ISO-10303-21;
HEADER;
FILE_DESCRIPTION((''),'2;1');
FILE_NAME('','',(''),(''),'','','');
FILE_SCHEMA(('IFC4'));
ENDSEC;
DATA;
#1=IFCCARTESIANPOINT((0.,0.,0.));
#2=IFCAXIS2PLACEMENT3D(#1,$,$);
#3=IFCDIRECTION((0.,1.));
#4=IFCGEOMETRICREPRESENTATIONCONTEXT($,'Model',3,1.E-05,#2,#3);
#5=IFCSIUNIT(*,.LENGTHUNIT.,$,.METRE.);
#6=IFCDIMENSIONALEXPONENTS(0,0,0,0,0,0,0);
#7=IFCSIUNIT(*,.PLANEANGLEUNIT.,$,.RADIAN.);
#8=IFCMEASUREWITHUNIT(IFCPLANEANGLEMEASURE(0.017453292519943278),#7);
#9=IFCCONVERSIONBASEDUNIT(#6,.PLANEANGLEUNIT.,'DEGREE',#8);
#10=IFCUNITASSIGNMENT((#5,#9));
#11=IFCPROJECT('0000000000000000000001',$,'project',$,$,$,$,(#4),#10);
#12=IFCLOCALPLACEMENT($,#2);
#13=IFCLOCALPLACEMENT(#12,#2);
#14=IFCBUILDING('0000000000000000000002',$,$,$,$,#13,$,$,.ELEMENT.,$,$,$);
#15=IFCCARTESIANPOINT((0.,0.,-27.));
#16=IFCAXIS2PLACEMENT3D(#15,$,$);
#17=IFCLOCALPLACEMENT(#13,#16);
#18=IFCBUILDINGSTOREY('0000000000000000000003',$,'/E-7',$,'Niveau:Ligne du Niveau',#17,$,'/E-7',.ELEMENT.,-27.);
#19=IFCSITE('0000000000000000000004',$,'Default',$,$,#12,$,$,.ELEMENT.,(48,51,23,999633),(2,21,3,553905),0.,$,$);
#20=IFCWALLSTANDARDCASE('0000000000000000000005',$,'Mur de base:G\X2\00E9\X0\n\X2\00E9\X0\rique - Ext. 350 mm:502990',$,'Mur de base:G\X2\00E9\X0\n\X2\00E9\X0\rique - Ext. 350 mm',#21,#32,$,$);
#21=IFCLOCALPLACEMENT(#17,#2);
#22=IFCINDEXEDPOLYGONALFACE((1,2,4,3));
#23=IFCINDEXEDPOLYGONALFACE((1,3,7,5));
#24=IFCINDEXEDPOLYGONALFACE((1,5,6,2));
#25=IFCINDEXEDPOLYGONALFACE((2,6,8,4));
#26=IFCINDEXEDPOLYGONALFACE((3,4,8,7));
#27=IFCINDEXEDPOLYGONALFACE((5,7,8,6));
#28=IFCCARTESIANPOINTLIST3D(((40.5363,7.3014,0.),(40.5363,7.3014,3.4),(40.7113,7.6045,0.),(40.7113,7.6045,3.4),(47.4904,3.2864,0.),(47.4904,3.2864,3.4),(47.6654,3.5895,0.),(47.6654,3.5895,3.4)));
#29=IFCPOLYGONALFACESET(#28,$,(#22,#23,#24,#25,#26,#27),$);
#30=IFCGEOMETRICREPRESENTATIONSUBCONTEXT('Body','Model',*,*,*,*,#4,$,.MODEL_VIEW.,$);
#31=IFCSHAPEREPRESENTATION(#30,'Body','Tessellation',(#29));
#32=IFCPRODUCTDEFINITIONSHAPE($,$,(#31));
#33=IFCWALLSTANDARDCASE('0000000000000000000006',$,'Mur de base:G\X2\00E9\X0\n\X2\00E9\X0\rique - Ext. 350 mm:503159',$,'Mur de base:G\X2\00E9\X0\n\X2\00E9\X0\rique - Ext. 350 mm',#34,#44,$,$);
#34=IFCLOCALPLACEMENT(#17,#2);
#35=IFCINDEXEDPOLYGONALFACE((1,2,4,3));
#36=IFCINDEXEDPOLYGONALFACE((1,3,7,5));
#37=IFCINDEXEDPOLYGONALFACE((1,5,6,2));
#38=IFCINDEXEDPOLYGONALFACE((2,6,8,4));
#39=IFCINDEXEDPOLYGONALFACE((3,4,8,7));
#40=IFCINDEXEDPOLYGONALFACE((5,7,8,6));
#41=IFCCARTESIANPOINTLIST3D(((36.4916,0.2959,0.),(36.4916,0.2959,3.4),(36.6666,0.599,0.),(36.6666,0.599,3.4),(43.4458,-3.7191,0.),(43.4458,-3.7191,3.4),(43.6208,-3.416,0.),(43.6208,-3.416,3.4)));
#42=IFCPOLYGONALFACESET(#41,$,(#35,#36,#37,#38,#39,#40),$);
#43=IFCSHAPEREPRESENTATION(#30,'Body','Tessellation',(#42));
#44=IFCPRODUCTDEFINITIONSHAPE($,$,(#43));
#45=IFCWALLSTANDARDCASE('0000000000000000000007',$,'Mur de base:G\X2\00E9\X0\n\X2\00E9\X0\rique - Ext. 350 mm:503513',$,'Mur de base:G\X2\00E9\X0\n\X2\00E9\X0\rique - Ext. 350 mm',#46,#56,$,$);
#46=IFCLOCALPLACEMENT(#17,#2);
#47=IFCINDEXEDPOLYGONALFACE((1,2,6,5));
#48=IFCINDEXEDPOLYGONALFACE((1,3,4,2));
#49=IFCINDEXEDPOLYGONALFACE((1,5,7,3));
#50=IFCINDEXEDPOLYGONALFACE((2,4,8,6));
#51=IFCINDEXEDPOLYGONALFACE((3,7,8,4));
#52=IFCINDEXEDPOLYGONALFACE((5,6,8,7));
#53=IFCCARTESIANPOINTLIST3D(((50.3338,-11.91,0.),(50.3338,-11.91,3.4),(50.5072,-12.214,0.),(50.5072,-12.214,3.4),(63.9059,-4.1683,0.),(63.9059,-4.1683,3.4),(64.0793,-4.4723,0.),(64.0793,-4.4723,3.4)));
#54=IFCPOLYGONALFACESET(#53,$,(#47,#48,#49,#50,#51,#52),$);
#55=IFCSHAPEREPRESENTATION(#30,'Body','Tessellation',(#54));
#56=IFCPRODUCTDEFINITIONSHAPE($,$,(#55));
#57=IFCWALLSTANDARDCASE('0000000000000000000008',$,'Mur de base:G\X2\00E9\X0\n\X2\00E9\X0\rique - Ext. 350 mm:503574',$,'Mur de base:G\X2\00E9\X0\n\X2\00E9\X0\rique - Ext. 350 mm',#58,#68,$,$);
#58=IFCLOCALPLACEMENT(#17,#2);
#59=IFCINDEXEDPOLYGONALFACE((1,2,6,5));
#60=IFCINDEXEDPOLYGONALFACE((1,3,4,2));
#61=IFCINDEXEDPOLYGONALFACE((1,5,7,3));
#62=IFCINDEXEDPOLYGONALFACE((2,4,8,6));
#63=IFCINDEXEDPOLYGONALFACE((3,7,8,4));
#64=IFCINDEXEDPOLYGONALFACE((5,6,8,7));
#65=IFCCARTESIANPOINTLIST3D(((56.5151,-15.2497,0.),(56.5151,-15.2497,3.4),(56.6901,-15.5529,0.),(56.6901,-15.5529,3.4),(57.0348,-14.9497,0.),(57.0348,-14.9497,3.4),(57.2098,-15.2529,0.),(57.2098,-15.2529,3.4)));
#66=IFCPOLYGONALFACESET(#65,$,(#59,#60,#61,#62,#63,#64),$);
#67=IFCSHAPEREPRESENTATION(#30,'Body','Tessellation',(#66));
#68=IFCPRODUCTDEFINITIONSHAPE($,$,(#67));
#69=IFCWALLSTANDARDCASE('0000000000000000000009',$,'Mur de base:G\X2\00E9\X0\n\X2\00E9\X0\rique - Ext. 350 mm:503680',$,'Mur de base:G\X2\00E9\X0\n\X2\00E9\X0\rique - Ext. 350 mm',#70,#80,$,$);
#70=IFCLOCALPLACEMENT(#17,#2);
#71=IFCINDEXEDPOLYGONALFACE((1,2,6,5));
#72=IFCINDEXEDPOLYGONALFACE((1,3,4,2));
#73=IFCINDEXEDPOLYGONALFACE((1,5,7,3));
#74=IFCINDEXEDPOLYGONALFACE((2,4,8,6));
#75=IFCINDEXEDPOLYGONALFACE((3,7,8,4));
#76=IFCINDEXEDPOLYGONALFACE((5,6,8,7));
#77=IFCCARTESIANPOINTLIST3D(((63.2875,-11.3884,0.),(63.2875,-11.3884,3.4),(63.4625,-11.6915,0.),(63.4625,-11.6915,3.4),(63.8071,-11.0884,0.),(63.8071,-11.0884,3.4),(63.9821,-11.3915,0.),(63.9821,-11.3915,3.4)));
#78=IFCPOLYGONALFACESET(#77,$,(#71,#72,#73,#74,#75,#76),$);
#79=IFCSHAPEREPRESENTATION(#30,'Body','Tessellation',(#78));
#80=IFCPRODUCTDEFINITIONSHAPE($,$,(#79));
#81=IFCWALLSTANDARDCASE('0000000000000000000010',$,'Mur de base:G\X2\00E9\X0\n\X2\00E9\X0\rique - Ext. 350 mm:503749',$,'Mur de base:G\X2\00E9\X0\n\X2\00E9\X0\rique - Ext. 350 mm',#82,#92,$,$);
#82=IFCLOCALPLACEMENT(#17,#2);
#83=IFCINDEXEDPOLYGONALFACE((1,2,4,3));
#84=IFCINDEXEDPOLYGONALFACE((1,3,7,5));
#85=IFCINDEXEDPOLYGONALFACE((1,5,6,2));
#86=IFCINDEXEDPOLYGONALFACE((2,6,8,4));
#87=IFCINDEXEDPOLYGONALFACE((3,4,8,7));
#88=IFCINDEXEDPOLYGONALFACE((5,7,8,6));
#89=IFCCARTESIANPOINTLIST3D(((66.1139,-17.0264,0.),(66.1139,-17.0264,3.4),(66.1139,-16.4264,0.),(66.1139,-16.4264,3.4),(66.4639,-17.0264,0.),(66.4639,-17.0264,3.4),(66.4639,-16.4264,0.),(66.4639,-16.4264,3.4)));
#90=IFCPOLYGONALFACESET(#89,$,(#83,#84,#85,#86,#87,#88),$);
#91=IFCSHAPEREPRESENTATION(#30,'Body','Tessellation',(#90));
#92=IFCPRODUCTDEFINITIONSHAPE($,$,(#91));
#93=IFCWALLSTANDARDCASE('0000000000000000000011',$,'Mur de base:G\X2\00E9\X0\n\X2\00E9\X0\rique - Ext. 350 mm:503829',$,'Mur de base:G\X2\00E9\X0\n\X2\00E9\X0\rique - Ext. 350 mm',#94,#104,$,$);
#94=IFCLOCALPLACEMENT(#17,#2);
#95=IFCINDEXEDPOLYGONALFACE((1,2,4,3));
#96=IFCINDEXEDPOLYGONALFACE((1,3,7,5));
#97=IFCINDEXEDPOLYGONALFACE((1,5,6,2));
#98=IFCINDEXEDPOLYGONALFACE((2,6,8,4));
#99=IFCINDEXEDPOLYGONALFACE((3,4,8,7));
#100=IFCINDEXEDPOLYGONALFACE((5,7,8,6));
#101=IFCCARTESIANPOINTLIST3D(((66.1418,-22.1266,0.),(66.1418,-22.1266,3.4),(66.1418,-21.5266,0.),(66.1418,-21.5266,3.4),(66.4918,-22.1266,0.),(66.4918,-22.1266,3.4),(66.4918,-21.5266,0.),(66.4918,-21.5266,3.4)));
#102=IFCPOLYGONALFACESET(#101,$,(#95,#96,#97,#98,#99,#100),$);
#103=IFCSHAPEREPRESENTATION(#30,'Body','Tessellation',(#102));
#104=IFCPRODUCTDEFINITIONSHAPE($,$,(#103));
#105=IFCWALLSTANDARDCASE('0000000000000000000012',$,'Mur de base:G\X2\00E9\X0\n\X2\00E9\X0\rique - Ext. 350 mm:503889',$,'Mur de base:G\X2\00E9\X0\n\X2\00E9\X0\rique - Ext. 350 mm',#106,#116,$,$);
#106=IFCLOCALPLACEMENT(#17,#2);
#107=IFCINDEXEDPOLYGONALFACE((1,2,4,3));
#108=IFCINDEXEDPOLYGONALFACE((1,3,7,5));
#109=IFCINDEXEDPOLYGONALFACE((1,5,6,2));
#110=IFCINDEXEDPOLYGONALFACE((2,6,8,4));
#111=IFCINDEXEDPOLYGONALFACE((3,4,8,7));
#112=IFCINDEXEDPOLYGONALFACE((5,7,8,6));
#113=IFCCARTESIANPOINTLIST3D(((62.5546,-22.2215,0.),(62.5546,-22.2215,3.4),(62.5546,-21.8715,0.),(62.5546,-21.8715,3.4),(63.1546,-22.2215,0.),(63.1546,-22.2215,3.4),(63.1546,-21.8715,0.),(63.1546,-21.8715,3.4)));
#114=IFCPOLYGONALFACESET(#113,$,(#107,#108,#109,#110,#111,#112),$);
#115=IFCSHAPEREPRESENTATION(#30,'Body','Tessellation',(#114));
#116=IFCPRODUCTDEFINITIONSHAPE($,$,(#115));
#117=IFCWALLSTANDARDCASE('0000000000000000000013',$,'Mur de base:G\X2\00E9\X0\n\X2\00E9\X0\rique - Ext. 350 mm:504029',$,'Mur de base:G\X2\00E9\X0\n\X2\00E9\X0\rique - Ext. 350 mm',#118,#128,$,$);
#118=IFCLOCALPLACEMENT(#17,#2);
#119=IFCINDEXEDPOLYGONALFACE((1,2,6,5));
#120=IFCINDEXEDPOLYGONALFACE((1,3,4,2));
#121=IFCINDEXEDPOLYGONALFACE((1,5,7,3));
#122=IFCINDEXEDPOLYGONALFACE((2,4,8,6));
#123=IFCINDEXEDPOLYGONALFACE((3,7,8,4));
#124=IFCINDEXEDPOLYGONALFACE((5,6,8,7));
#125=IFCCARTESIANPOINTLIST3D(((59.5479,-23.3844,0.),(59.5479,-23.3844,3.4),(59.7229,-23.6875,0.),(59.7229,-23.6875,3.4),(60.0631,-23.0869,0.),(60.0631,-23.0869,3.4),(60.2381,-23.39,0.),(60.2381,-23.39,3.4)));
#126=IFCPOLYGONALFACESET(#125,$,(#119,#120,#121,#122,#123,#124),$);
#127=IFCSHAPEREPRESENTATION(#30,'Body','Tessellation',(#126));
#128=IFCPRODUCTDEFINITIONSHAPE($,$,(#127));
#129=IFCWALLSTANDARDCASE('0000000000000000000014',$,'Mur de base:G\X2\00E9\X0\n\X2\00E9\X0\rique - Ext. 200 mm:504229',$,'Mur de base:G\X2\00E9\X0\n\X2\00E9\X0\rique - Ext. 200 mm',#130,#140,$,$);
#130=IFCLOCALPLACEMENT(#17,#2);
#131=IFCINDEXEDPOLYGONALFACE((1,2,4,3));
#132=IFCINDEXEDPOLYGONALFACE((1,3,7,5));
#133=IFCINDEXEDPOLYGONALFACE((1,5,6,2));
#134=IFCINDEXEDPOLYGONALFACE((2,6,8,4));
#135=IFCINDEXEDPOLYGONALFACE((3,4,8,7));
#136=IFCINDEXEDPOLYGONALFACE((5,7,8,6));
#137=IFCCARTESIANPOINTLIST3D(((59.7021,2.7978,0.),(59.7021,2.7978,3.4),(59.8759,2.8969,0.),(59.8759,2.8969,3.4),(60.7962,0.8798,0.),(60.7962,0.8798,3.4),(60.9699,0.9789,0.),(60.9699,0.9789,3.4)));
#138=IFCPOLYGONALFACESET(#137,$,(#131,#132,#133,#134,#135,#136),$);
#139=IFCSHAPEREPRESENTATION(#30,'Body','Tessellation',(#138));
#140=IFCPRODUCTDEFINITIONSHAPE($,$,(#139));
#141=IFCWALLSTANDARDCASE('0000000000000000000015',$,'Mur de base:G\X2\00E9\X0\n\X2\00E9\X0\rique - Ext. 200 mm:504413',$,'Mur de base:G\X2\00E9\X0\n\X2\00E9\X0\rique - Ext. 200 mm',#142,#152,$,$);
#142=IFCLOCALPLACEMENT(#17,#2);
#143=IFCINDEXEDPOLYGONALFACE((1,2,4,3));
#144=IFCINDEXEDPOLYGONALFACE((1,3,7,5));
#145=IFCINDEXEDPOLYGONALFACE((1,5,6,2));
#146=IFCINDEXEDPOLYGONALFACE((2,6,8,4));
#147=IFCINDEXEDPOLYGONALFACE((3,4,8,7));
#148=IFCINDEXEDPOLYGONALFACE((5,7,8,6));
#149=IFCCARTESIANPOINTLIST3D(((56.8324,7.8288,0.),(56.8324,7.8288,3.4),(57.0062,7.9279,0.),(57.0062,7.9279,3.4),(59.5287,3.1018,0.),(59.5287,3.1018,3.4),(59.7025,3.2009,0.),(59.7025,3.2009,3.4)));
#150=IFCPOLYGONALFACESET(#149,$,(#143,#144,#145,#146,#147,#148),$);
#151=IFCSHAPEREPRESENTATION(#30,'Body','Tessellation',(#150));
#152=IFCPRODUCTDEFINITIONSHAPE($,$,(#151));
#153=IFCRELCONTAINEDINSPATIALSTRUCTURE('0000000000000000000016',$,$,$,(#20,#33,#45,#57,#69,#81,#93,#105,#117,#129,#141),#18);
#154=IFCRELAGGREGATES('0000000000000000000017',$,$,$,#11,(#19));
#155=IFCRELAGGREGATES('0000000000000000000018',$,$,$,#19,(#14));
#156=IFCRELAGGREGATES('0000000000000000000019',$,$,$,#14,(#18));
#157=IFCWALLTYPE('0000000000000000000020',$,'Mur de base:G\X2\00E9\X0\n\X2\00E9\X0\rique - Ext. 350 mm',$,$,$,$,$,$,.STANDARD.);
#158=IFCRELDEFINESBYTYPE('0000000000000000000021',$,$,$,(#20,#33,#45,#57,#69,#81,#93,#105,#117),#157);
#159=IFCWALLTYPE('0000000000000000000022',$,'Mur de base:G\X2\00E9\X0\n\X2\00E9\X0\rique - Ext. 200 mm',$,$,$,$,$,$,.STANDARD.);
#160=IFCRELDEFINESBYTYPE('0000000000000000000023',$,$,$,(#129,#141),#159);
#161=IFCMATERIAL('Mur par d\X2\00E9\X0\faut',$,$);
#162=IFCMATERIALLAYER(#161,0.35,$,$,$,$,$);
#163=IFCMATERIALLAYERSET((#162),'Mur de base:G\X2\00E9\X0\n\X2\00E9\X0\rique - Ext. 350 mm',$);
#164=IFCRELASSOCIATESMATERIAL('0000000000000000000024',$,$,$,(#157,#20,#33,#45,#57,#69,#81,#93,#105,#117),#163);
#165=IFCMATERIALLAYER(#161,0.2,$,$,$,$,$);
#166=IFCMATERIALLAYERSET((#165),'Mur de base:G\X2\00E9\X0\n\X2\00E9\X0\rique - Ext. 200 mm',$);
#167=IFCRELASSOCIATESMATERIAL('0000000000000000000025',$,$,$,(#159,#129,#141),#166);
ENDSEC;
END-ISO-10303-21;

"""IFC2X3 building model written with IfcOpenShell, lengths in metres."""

from ifc_helpers import new_model, entity, si_unit, converted_unit, direction, frame, frame_2d, origin, place, context, subcontext, project, spatial, rectangle, extrude, material, layer, layer_set, layer_usage, type_object, element, save


model = new_model("IFC2X3")

# Units and contexts
model_context = context("Model", 3, precision=1e-05, world=origin(), true_north=direction((0.0, 1.0)))
body_context = subcontext(model_context, "Body", "Model", "MODEL_VIEW")
ifc_project = project(units=[si_unit("LENGTHUNIT", "METRE"), converted_unit("PLANEANGLEUNIT", "DEGREE", entity("IfcPlaneAngleMeasure", 0.017453292519943278), si_unit("PLANEANGLEUNIT", "RADIAN"), dimensions=[0, 0, 0, 0, 0, 0, 0])], contexts=[model_context])

# Site, building, storey
site_placement = place(None, origin())
site = spatial("IfcSite", under=ifc_project, at=site_placement, Name="Default", CompositionType="ELEMENT", RefLatitude=(48, 51, 23, 999633), RefLongitude=(2, 21, 3, 553905), RefElevation=0.0)
building_placement = place(site_placement, origin())
building = spatial("IfcBuilding", under=site, at=building_placement, CompositionType="ELEMENT")
storey_placement = place(building_placement, frame((0.0, 0.0, -27.0)))
storey = spatial("IfcBuildingStorey", under=building, at=storey_placement, Name="/E-7", ObjectType="Niveau:Ligne du Niveau", LongName="/E-7", CompositionType="ELEMENT", Elevation=-27.0)

# Shared definitions
ifc_material_1 = material(Name="Mur par défaut")
ifc_layer_1 = layer(ifc_material_1, 0.35)
ifc_layer_set_1 = layer_set([ifc_layer_1], Name="Mur de base:Générique - Ext. 350 mm")
wall_type_1 = type_object("IfcWallType", Name="Mur de base:Générique - Ext. 350 mm", PredefinedType="STANDARD", material=ifc_layer_set_1)

# Walls
ifc_layer_usage_1 = layer_usage(ifc_layer_set_1, "AXIS2", "NEGATIVE", 0.175)
wall_1_placement = place(storey_placement, frame((40.6238, 7.4529, 0.0), z_axis=(0.0, 0.0, 1.0), x_axis=(0.866025, -0.5, 0.0)))
element("IfcWallStandardCase", 1, at=wall_1_placement, inside=storey, type_object=wall_type_1, material=ifc_layer_usage_1, Name="Mur de base:Générique - Ext. 350 mm:502990", ObjectType="Mur de base:Générique - Ext. 350 mm", context=body_context, shape_type="SweptSolid", body=[
    extrude(rectangle(XDim=8.03, YDim=0.35, at=frame_2d((4.015, 0.0), x_axis=(-1.0, 0.0))), origin(), (0.0, 0.0, 1.0), 3.4),
])
ifc_layer_usage_2 = layer_usage(ifc_layer_set_1, "AXIS2", "NEGATIVE", 0.175)
wall_2_placement = place(storey_placement, frame((36.5791, 0.4474, 0.0), z_axis=(0.0, 0.0, 1.0), x_axis=(0.866025, -0.5, 0.0)))
element("IfcWallStandardCase", 2, at=wall_2_placement, inside=storey, type_object=wall_type_1, material=ifc_layer_usage_2, Name="Mur de base:Générique - Ext. 350 mm:503159", ObjectType="Mur de base:Générique - Ext. 350 mm", context=body_context, shape_type="SweptSolid", body=[
    extrude(rectangle(XDim=8.03, YDim=0.35, at=frame_2d((4.015, 0.0), x_axis=(-1.0, 0.0))), origin(), (0.0, 0.0, 1.0), 3.4),
])
ifc_layer_usage_3 = layer_usage(ifc_layer_set_1, "AXIS2", "NEGATIVE", 0.175)
wall_3_placement = place(storey_placement, frame((50.4205, -12.062, 0.0), z_axis=(0.0, 0.0, 1.0), x_axis=(0.868625, 0.495469, 0.0)))
element("IfcWallStandardCase", 3, at=wall_3_placement, inside=storey, type_object=wall_type_1, material=ifc_layer_usage_3, Name="Mur de base:Générique - Ext. 350 mm:503513", ObjectType="Mur de base:Générique - Ext. 350 mm", context=body_context, shape_type="SweptSolid", body=[
    extrude(rectangle(XDim=15.6248, YDim=0.35, at=frame_2d((7.8124, 0.0), x_axis=(-1.0, 0.0))), origin(), (0.0, 0.0, 1.0), 3.4),
])
ifc_layer_usage_4 = layer_usage(ifc_layer_set_1, "AXIS2", "NEGATIVE", 0.175)
wall_4_placement = place(storey_placement, frame((56.6026, -15.4013, 0.0), z_axis=(0.0, 0.0, 1.0), x_axis=(0.866025, 0.5, 0.0)))
element("IfcWallStandardCase", 4, at=wall_4_placement, inside=storey, type_object=wall_type_1, material=ifc_layer_usage_4, Name="Mur de base:Générique - Ext. 350 mm:503574", ObjectType="Mur de base:Générique - Ext. 350 mm", context=body_context, shape_type="SweptSolid", body=[
    extrude(rectangle(XDim=0.6, YDim=0.35, at=frame_2d((0.3, 0.0), x_axis=(-1.0, 0.0))), origin(), (0.0, 0.0, 1.0), 3.4),
])
ifc_layer_usage_5 = layer_usage(ifc_layer_set_1, "AXIS2", "NEGATIVE", 0.175)
wall_5_placement = place(storey_placement, frame((63.375, -11.54, 0.0), z_axis=(0.0, 0.0, 1.0), x_axis=(0.866025, 0.5, 0.0)))
element("IfcWallStandardCase", 5, at=wall_5_placement, inside=storey, type_object=wall_type_1, material=ifc_layer_usage_5, Name="Mur de base:Générique - Ext. 350 mm:503680", ObjectType="Mur de base:Générique - Ext. 350 mm", context=body_context, shape_type="SweptSolid", body=[
    extrude(rectangle(XDim=0.6, YDim=0.35, at=frame_2d((0.3, 0.0), x_axis=(-1.0, 0.0))), origin(), (0.0, 0.0, 1.0), 3.4),
])
ifc_layer_usage_6 = layer_usage(ifc_layer_set_1, "AXIS2", "NEGATIVE", 0.175)
wall_6_placement = place(storey_placement, frame((66.2889, -16.4264, 0.0), z_axis=(0.0, 0.0, 1.0), x_axis=(0.0, -1.0, 0.0)))
element("IfcWallStandardCase", 6, at=wall_6_placement, inside=storey, type_object=wall_type_1, material=ifc_layer_usage_6, Name="Mur de base:Générique - Ext. 350 mm:503749", ObjectType="Mur de base:Générique - Ext. 350 mm", context=body_context, shape_type="SweptSolid", body=[
    extrude(rectangle(XDim=0.6, YDim=0.35, at=frame_2d((0.3, 0.0), x_axis=(-1.0, 0.0))), origin(), (0.0, 0.0, 1.0), 3.4),
])
ifc_layer_usage_7 = layer_usage(ifc_layer_set_1, "AXIS2", "NEGATIVE", 0.175)
wall_7_placement = place(storey_placement, frame((66.3168, -21.5266, 0.0), z_axis=(0.0, 0.0, 1.0), x_axis=(0.0, -1.0, 0.0)))
element("IfcWallStandardCase", 7, at=wall_7_placement, inside=storey, type_object=wall_type_1, material=ifc_layer_usage_7, Name="Mur de base:Générique - Ext. 350 mm:503829", ObjectType="Mur de base:Générique - Ext. 350 mm", context=body_context, shape_type="SweptSolid", body=[
    extrude(rectangle(XDim=0.6, YDim=0.35, at=frame_2d((0.3, 0.0), x_axis=(-1.0, 0.0))), origin(), (0.0, 0.0, 1.0), 3.4),
])
ifc_layer_usage_8 = layer_usage(ifc_layer_set_1, "AXIS2", "NEGATIVE", 0.175)
wall_8_placement = place(storey_placement, frame((63.1546, -22.0465, 0.0), z_axis=(0.0, 0.0, 1.0), x_axis=(-1.0, 0.0, 0.0)))
element("IfcWallStandardCase", 8, at=wall_8_placement, inside=storey, type_object=wall_type_1, material=ifc_layer_usage_8, Name="Mur de base:Générique - Ext. 350 mm:503889", ObjectType="Mur de base:Générique - Ext. 350 mm", context=body_context, shape_type="SweptSolid", body=[
    extrude(rectangle(XDim=0.6, YDim=0.35, at=frame_2d((0.3, 0.0), x_axis=(-1.0, 0.0))), origin(), (0.0, 0.0, 1.0), 3.4),
])
ifc_layer_usage_9 = layer_usage(ifc_layer_set_1, "AXIS2", "NEGATIVE", 0.175)
wall_9_placement = place(storey_placement, frame((60.1506, -23.2385, 0.0), z_axis=(0.0, 0.0, 1.0), x_axis=(-0.866025, -0.5, 0.0)))
element("IfcWallStandardCase", 9, at=wall_9_placement, inside=storey, type_object=wall_type_1, material=ifc_layer_usage_9, Name="Mur de base:Générique - Ext. 350 mm:504029", ObjectType="Mur de base:Générique - Ext. 350 mm", context=body_context, shape_type="SweptSolid", body=[
    extrude(rectangle(XDim=0.595, YDim=0.35, at=frame_2d((0.2975, 0.0), x_axis=(-1.0, 0.0))), origin(), (0.0, 0.0, 1.0), 3.4),
])
ifc_layer_2 = layer(ifc_material_1, 0.2)
ifc_layer_set_2 = layer_set([ifc_layer_2], Name="Mur de base:Générique - Ext. 200 mm")
ifc_layer_usage_10 = layer_usage(ifc_layer_set_2, "AXIS2", "NEGATIVE", 0.1)
wall_type_2 = type_object("IfcWallType", Name="Mur de base:Générique - Ext. 200 mm", PredefinedType="STANDARD", material=ifc_layer_set_2)
wall_10_placement = place(storey_placement, frame((60.883, 0.9294, 0.0), z_axis=(0.0, 0.0, 1.0), x_axis=(-0.495469, 0.868625, 0.0)))
element("IfcWallStandardCase", 10, at=wall_10_placement, inside=storey, type_object=wall_type_2, material=ifc_layer_usage_10, Name="Mur de base:Générique - Ext. 200 mm:504229", ObjectType="Mur de base:Générique - Ext. 200 mm", context=body_context, shape_type="SweptSolid", body=[
    extrude(rectangle(XDim=2.2081, YDim=0.2, at=frame_2d((1.104, 0.0), x_axis=(-1.0, 0.0))), origin(), (0.0, 0.0, 1.0), 3.4),
])
ifc_layer_usage_11 = layer_usage(ifc_layer_set_2, "AXIS2", "NEGATIVE", 0.1)
wall_11_placement = place(storey_placement, frame((59.6156, 3.1514, 0.0), z_axis=(0.0, 0.0, 1.0), x_axis=(-0.495469, 0.868625, 0.0)))
element("IfcWallStandardCase", 11, at=wall_11_placement, inside=storey, type_object=wall_type_2, material=ifc_layer_usage_11, Name="Mur de base:Générique - Ext. 200 mm:504413", ObjectType="Mur de base:Générique - Ext. 200 mm", context=body_context, shape_type="SweptSolid", body=[
    extrude(rectangle(XDim=5.4419, YDim=0.2, at=frame_2d((2.721, 0.0), x_axis=(-1.0, 0.0))), origin(), (0.0, 0.0, 1.0), 3.4),
])

save(model, "model.ifc")
